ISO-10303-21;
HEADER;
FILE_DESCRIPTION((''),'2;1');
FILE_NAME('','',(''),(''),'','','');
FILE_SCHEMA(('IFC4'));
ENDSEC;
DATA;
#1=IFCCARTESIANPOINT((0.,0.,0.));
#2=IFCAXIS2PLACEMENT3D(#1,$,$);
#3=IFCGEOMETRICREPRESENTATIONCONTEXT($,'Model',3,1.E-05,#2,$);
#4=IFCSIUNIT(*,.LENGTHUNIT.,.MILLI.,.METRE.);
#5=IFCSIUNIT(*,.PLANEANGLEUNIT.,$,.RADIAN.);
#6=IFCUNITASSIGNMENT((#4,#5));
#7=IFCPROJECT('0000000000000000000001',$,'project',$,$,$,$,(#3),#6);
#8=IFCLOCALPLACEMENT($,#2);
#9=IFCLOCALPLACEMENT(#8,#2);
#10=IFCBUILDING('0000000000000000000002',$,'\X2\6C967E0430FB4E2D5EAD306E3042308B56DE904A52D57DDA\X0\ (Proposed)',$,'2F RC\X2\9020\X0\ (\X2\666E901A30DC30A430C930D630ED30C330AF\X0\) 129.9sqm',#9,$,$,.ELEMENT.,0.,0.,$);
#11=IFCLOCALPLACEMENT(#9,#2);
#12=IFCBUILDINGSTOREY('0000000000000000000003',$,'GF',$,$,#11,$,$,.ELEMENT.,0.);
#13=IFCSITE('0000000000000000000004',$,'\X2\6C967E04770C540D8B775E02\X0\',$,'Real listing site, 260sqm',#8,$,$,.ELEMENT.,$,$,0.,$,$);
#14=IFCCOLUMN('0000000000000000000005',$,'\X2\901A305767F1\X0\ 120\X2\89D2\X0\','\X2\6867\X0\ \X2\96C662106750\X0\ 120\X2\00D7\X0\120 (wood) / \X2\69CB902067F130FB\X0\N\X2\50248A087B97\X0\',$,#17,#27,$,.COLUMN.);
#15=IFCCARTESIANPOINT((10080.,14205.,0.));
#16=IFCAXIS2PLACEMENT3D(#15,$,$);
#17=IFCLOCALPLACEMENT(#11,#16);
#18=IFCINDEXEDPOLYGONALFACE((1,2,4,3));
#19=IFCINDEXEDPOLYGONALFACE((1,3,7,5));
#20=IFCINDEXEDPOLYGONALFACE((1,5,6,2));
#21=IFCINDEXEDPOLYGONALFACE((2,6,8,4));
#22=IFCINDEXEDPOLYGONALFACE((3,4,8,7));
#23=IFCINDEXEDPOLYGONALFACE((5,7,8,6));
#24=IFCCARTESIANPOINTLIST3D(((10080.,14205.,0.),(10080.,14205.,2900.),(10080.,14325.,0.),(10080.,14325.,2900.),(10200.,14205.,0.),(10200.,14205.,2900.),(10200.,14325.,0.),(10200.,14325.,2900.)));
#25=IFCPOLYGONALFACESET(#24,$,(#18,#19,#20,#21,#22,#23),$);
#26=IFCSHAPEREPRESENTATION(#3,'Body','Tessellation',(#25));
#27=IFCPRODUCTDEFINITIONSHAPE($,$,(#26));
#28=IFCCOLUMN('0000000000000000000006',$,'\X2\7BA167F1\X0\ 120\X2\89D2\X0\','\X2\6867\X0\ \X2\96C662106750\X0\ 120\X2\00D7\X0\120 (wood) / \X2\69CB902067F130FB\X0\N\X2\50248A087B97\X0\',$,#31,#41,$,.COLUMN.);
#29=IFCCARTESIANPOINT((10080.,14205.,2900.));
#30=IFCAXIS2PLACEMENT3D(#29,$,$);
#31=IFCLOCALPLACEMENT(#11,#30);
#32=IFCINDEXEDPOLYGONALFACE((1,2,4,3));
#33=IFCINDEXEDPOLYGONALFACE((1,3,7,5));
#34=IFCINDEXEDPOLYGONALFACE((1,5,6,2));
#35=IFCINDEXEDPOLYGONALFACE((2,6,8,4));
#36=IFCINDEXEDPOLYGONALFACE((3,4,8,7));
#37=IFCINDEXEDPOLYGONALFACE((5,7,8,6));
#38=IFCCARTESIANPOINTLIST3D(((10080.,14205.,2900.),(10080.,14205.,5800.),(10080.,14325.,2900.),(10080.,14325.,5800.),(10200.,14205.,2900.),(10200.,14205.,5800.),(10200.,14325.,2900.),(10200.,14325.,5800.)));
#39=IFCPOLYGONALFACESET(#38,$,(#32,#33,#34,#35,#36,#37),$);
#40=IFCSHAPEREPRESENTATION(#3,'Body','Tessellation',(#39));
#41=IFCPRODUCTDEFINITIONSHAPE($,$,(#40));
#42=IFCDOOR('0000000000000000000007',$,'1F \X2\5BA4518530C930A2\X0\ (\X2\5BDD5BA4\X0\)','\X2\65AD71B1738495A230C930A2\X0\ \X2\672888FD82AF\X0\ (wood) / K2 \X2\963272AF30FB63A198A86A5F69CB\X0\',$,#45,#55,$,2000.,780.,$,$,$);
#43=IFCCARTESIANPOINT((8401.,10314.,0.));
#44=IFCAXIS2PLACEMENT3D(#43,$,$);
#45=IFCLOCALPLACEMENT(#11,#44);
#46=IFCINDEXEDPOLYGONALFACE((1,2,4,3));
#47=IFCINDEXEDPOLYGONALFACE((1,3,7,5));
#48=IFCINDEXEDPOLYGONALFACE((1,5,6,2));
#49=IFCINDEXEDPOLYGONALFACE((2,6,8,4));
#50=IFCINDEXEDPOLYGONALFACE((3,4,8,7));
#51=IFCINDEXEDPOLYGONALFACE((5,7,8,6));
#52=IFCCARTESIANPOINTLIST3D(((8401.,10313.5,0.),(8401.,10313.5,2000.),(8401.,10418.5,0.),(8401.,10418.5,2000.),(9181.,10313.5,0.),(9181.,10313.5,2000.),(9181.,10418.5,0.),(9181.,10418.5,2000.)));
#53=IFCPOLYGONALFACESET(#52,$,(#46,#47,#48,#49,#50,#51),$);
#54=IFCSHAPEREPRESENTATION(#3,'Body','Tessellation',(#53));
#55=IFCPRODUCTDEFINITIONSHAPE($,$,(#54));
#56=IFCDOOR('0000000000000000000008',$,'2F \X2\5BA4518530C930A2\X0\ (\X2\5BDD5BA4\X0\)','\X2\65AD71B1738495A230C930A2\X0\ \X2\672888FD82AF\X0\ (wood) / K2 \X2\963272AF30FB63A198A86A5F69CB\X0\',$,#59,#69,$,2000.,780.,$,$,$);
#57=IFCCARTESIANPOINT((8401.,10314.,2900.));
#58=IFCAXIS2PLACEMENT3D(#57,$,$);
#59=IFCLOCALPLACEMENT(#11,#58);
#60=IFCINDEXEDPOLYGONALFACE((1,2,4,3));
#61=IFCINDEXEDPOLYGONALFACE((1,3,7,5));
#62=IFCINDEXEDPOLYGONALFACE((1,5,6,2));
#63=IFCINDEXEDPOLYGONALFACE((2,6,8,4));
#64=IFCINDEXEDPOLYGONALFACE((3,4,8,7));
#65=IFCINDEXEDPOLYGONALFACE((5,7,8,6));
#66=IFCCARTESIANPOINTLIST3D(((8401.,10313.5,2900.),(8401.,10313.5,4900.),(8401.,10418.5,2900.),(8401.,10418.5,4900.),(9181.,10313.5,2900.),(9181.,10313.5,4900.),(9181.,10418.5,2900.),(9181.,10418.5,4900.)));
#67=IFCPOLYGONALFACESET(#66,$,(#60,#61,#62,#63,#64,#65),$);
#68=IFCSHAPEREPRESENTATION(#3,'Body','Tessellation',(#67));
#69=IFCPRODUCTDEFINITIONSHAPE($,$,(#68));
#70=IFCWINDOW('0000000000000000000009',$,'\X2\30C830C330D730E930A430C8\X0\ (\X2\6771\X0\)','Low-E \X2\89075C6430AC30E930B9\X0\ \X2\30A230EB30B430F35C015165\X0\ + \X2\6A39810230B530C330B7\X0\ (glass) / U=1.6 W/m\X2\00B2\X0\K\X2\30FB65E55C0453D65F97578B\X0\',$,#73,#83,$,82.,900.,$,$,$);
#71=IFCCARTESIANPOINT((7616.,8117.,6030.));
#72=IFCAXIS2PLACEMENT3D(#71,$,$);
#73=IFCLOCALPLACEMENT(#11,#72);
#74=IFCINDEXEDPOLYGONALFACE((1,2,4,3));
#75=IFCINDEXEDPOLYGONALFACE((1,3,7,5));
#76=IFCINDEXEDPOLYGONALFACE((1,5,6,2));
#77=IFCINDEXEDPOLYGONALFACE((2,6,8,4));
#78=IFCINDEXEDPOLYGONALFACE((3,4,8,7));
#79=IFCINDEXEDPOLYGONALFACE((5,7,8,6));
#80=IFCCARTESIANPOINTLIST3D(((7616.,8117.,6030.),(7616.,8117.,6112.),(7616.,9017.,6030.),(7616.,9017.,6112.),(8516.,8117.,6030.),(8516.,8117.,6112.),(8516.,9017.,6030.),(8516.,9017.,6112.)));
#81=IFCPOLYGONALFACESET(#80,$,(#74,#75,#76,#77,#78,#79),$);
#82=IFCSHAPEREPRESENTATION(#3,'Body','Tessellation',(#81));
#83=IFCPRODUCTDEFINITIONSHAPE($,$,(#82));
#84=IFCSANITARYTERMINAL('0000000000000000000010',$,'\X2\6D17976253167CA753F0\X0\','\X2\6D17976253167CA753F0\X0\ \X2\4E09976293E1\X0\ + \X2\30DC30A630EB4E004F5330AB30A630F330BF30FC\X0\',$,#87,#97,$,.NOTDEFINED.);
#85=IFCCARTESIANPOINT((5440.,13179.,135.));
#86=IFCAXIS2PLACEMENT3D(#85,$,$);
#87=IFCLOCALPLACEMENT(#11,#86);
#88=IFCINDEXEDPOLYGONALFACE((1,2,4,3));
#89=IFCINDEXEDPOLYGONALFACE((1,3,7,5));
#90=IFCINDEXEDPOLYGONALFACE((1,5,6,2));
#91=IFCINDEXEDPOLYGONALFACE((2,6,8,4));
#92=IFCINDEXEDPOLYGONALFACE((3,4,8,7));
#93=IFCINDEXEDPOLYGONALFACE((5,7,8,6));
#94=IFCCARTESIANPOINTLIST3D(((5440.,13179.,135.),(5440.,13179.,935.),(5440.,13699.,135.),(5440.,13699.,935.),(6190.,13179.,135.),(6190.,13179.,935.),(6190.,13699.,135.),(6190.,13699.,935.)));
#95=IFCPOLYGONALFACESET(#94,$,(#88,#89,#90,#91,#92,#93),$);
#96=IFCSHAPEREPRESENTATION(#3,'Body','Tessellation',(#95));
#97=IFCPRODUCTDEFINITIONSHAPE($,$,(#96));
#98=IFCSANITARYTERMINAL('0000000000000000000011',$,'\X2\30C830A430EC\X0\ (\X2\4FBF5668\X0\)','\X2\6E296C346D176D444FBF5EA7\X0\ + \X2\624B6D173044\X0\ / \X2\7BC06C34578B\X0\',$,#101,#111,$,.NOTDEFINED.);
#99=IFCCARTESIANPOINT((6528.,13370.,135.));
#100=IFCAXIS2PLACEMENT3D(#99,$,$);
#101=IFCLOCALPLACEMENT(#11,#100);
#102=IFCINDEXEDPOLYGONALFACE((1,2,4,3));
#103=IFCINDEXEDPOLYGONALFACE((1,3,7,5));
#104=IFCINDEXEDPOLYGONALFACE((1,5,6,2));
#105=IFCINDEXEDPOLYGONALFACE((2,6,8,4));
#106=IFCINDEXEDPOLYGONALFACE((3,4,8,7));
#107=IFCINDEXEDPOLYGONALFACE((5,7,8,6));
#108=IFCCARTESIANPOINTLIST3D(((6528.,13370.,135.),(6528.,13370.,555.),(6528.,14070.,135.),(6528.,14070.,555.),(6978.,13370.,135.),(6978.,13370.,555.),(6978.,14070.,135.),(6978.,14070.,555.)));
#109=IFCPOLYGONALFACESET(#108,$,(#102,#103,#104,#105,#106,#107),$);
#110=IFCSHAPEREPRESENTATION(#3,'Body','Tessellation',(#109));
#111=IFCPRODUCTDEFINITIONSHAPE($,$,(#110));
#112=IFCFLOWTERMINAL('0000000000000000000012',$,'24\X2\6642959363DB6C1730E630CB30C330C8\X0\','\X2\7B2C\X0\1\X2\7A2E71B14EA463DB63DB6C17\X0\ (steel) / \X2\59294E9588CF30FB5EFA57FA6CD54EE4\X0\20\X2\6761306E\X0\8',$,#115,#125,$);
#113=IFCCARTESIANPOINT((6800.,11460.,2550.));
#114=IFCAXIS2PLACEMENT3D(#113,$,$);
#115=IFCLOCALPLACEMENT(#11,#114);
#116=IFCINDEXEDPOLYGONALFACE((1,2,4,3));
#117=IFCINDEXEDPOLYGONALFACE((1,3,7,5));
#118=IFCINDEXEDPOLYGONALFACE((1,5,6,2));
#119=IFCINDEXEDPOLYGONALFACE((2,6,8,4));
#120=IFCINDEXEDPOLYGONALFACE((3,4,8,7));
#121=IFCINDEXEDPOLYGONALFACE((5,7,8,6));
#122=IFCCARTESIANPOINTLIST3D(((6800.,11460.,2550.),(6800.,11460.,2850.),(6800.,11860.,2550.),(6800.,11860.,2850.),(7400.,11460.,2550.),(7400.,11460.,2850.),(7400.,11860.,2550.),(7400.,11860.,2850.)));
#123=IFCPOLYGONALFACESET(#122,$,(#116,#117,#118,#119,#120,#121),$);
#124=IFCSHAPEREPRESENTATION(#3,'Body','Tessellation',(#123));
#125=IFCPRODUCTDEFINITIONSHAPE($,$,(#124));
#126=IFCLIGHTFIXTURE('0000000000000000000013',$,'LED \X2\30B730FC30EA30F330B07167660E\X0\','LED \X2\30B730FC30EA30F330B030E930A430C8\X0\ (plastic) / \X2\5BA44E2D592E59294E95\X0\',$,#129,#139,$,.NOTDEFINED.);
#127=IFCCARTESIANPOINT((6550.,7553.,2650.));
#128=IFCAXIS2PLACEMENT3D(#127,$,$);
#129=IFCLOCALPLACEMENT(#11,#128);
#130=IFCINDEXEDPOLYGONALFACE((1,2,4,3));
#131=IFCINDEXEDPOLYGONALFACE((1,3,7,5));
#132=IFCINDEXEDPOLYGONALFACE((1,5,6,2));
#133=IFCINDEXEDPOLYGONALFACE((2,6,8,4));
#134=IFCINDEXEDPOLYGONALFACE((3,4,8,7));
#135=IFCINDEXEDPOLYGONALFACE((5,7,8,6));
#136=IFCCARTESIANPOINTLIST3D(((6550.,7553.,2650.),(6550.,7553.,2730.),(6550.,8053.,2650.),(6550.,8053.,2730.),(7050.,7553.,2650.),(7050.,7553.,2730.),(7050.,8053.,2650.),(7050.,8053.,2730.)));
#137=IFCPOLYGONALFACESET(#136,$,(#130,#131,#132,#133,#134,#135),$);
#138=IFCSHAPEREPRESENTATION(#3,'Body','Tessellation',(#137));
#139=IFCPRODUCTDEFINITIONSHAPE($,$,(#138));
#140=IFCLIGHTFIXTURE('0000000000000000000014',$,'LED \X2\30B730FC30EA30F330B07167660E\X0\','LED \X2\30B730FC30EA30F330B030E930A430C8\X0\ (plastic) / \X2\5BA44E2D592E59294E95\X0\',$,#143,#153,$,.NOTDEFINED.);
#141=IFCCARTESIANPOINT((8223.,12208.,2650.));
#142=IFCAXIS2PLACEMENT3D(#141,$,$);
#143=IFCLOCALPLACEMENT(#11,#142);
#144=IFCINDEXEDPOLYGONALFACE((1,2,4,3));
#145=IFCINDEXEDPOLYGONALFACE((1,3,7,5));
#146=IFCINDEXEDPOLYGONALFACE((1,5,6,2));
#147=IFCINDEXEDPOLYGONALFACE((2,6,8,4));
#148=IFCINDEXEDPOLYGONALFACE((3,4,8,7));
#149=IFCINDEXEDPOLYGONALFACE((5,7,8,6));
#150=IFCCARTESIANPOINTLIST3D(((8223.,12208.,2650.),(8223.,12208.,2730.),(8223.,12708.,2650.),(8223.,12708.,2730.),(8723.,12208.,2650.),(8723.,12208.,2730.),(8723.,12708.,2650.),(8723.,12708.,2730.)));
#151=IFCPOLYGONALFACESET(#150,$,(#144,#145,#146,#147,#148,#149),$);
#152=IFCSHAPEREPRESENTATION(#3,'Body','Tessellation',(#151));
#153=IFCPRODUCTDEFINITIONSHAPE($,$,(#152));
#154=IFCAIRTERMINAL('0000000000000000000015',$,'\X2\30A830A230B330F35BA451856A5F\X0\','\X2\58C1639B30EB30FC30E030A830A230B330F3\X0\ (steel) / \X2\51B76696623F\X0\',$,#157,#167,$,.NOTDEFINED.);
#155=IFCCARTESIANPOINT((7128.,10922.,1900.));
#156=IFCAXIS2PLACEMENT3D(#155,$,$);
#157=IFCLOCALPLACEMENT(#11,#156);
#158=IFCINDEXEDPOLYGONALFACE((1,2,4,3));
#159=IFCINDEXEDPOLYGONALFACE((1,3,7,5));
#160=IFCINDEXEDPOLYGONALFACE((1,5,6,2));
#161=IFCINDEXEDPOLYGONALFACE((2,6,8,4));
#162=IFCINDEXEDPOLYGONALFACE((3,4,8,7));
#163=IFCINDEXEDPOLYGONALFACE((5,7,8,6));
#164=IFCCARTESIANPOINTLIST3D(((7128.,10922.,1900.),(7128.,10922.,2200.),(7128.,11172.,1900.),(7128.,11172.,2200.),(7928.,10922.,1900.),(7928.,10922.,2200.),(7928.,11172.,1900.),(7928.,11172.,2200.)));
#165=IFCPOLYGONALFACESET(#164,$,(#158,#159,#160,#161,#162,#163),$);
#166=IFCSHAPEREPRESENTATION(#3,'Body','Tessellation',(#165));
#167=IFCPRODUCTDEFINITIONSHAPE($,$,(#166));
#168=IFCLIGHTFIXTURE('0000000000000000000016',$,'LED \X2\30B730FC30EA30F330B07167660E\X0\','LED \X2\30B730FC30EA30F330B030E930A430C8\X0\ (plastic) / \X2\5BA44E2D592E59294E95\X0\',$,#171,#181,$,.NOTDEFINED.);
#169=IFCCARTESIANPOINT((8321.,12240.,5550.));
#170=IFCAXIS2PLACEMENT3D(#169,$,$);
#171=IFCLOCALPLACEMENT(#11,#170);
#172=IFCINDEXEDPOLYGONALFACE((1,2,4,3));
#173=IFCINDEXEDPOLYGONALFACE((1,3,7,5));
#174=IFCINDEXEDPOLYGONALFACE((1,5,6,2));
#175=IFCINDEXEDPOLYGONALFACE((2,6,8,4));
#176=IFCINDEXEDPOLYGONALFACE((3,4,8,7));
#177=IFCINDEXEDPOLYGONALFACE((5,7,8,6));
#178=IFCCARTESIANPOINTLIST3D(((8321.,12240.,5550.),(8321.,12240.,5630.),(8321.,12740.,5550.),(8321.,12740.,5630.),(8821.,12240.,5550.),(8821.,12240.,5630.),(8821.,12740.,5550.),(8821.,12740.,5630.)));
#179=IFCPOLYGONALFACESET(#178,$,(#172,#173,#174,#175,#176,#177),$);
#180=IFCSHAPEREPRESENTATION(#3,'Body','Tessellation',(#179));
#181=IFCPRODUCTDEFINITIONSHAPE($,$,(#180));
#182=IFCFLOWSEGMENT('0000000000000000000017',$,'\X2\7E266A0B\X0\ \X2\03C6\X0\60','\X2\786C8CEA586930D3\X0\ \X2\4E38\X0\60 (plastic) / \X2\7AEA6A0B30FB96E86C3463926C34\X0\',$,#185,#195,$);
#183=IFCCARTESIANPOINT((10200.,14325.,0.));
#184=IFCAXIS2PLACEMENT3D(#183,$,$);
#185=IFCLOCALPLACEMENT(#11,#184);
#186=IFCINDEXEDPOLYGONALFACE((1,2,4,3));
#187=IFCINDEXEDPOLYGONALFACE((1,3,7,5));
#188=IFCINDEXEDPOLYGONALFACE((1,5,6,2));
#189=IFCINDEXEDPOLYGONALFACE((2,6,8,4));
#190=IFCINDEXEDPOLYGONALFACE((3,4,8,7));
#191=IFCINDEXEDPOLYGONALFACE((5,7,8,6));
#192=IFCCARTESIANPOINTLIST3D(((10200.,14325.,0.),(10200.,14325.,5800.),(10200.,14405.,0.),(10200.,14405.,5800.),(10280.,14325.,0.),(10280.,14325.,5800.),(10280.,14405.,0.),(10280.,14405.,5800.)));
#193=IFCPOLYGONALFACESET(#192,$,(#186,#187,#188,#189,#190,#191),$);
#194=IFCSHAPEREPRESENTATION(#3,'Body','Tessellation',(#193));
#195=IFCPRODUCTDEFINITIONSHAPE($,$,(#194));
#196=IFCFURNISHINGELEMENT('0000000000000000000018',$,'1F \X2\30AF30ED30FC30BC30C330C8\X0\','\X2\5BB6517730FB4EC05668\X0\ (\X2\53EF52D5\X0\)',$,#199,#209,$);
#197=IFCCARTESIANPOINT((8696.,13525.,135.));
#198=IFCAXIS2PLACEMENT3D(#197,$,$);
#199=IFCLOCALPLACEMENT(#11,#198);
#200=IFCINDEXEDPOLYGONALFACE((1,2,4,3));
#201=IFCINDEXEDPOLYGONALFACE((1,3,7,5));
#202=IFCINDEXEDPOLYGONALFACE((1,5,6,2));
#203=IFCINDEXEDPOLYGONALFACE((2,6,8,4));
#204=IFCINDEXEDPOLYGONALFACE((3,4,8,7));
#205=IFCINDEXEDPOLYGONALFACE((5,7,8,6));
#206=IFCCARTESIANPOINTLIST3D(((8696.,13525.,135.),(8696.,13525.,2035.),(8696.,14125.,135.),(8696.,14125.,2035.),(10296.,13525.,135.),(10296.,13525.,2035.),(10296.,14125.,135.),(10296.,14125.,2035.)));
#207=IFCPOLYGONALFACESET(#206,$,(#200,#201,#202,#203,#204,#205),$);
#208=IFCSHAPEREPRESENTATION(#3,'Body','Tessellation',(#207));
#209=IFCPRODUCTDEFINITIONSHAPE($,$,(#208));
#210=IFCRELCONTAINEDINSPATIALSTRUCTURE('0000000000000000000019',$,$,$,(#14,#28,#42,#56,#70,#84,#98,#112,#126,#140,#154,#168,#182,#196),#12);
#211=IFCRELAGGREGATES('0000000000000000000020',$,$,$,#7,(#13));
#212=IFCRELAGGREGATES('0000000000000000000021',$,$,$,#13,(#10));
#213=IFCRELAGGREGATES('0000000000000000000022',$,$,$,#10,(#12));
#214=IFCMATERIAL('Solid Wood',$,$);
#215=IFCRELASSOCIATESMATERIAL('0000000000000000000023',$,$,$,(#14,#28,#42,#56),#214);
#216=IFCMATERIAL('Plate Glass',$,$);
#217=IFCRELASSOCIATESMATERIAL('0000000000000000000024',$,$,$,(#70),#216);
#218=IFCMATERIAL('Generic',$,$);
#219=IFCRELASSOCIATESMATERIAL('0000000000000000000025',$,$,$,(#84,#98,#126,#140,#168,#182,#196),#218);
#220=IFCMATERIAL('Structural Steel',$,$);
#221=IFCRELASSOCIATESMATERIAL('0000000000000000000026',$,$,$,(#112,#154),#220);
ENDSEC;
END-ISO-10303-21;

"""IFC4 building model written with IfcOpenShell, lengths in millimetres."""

from ifc_helpers import new_model, si_unit, frame, frame_2d, origin, place, context, project, spatial, rectangle, extrude, material, element, save


model = new_model("IFC4")

# Units and contexts
model_context = context("Model", 3, precision=1e-05, world=origin())
ifc_project = project(units=[si_unit("LENGTHUNIT", "METRE", prefix="MILLI"), si_unit("PLANEANGLEUNIT", "RADIAN")], contexts=[model_context])

# Site, building, storey
site_placement = place(None, origin())
site = spatial("IfcSite", under=ifc_project, at=site_placement, Name="沖縄県名護市", ObjectType="Real listing site, 260sqm", CompositionType="ELEMENT", RefElevation=0.0)
building_placement = place(site_placement, origin())
building = spatial("IfcBuilding", under=site, at=building_placement, Name="沖縄・中庭のある回遊動線 (Proposed)", ObjectType="2F RC造 (普通ボイドブロック) 129.9sqm", CompositionType="ELEMENT", ElevationOfRefHeight=0.0, ElevationOfTerrain=0.0)
storey_placement = place(building_placement, origin())
storey = spatial("IfcBuildingStorey", under=building, at=storey_placement, Name="GF", CompositionType="ELEMENT", Elevation=0.0)

# Columns
ifc_material_1 = material(Name="Solid Wood")
column_1_placement = place(storey_placement, frame((10080.0, 14205.0, 0.0)))
element("IfcColumn", 1, at=column_1_placement, inside=storey, material=ifc_material_1, Name="通し柱 120角", Description="桧 集成材 120×120 (wood) / 構造柱・N値計算", PredefinedType="COLUMN", context=model_context, shape_type="SweptSolid", body=[
    extrude(rectangle(XDim=120.0, YDim=120.0, at=frame_2d((60.0, 60.0))), frame((10080.0, 14205.0, 0.0)), (0.0, 0.0, 1.0), 2900.0),
])
column_2_placement = place(storey_placement, frame((10080.0, 14205.0, 2900.0)))
element("IfcColumn", 2, at=column_2_placement, inside=storey, material=ifc_material_1, Name="管柱 120角", Description="桧 集成材 120×120 (wood) / 構造柱・N値計算", PredefinedType="COLUMN", context=model_context, shape_type="SweptSolid", body=[
    extrude(rectangle(XDim=120.0, YDim=120.0, at=frame_2d((60.0, 60.0))), frame((10080.0, 14205.0, 2900.0)), (0.0, 0.0, 1.0), 2900.0),
])

# Door
door_1_placement = place(storey_placement, frame((8401.0, 10314.0, 0.0)))
element("IfcDoor", 3, at=door_1_placement, inside=storey, material=ifc_material_1, Name="1F 室内ドア (寝室)", Description="断熱玄関ドア 木製芯 (wood) / K2 防犯・採風機構", OverallHeight=2000.0, OverallWidth=780.0, context=model_context, shape_type="SweptSolid", body=[
    extrude(rectangle(XDim=780.0, YDim=105.0, at=frame_2d((390.0, 52.0))), frame((8401.0, 10314.0, 0.0)), (0.0, 0.0, 1.0), 2000.0),
])

# Door
door_2_placement = place(storey_placement, frame((8401.0, 10314.0, 2900.0)))
element("IfcDoor", 4, at=door_2_placement, inside=storey, material=ifc_material_1, Name="2F 室内ドア (寝室)", Description="断熱玄関ドア 木製芯 (wood) / K2 防犯・採風機構", OverallHeight=2000.0, OverallWidth=780.0, context=model_context, shape_type="SweptSolid", body=[
    extrude(rectangle(XDim=780.0, YDim=105.0, at=frame_2d((390.0, 52.0))), frame((8401.0, 10314.0, 2900.0)), (0.0, 0.0, 1.0), 2000.0),
])

# Window
ifc_material_2 = material(Name="Plate Glass")
window_placement = place(storey_placement, frame((7616.0, 8117.0, 6030.0)))
element("IfcWindow", 5, at=window_placement, inside=storey, material=ifc_material_2, Name="トップライト (東)", Description="Low-E 複層ガラス アルゴン封入 + 樹脂サッシ (glass) / U=1.6 W/m²K・日射取得型", OverallHeight=82.0, OverallWidth=900.0, context=model_context, shape_type="SweptSolid", body=[
    extrude(rectangle(XDim=900.0, YDim=900.0, at=frame_2d((450.0, 450.0))), frame((7616.0, 8117.0, 6030.0)), (0.0, 0.0, 1.0), 82.0),
])

# Sanitary terminals
ifc_material_3 = material(Name="Generic")
sanitary_terminal_1_placement = place(storey_placement, frame((5440.0, 13179.0, 135.0)))
element("IfcSanitaryTerminal", 6, at=sanitary_terminal_1_placement, inside=storey, material=ifc_material_3, Name="洗面化粧台", Description="洗面化粧台 三面鏡 + ボウル一体カウンター", PredefinedType="NOTDEFINED", context=model_context, shape_type="SweptSolid", body=[
    extrude(rectangle(XDim=750.0, YDim=520.0, at=frame_2d((375.0, 260.0))), frame((5440.0, 13179.0, 135.0)), (0.0, 0.0, 1.0), 800.0),
])
sanitary_terminal_2_placement = place(storey_placement, frame((6528.0, 13370.0, 135.0)))
element("IfcSanitaryTerminal", 7, at=sanitary_terminal_2_placement, inside=storey, material=ifc_material_3, Name="トイレ (便器)", Description="温水洗浄便座 + 手洗い / 節水型", PredefinedType="NOTDEFINED", context=model_context, shape_type="SweptSolid", body=[
    extrude(rectangle(XDim=450.0, YDim=700.0, at=frame_2d((225.0, 350.0))), frame((6528.0, 13370.0, 135.0)), (0.0, 0.0, 1.0), 420.0),
])

# Flow terminal
ifc_material_4 = material(Name="Structural Steel")
flow_terminal_placement = place(storey_placement, frame((6800.0, 11460.0, 2550.0)))
element("IfcFlowTerminal", 8, at=flow_terminal_placement, inside=storey, material=ifc_material_4, Name="24時間換気ユニット", Description="第1種熱交換換気 (steel) / 天井裏・建基法令20条の8", context=model_context, shape_type="SweptSolid", body=[
    extrude(rectangle(XDim=600.0, YDim=400.0, at=frame_2d((300.0, 200.0))), frame((6800.0, 11460.0, 2550.0)), (0.0, 0.0, 1.0), 300.0),
])

# Light fixtures
light_fixture_1_placement = place(storey_placement, frame((6550.0, 7553.0, 2650.0)))
element("IfcLightFixture", 9, at=light_fixture_1_placement, inside=storey, material=ifc_material_3, Name="LED シーリング照明", Description="LED シーリングライト (plastic) / 室中央天井", PredefinedType="NOTDEFINED", context=model_context, shape_type="SweptSolid", body=[
    extrude(rectangle(XDim=500.0, YDim=500.0, at=frame_2d((250.0, 250.0))), frame((6550.0, 7553.0, 2650.0)), (0.0, 0.0, 1.0), 80.0),
])
light_fixture_2_placement = place(storey_placement, frame((8223.0, 12208.0, 2650.0)))
element("IfcLightFixture", 10, at=light_fixture_2_placement, inside=storey, material=ifc_material_3, Name="LED シーリング照明", Description="LED シーリングライト (plastic) / 室中央天井", PredefinedType="NOTDEFINED", context=model_context, shape_type="SweptSolid", body=[
    extrude(rectangle(XDim=500.0, YDim=500.0, at=frame_2d((250.0, 250.0))), frame((8223.0, 12208.0, 2650.0)), (0.0, 0.0, 1.0), 80.0),
])

# Air terminal
air_terminal_placement = place(storey_placement, frame((7128.0, 10922.0, 1900.0)))
element("IfcAirTerminal", 11, at=air_terminal_placement, inside=storey, material=ifc_material_4, Name="エアコン室内機", Description="壁掛ルームエアコン (steel) / 冷暖房", PredefinedType="NOTDEFINED", context=model_context, shape_type="SweptSolid", body=[
    extrude(rectangle(XDim=800.0, YDim=250.0, at=frame_2d((400.0, 125.0))), frame((7128.0, 10922.0, 1900.0)), (0.0, 0.0, 1.0), 300.0),
])

# Light fixture
light_fixture_3_placement = place(storey_placement, frame((8321.0, 12240.0, 5550.0)))
element("IfcLightFixture", 12, at=light_fixture_3_placement, inside=storey, material=ifc_material_3, Name="LED シーリング照明", Description="LED シーリングライト (plastic) / 室中央天井", PredefinedType="NOTDEFINED", context=model_context, shape_type="SweptSolid", body=[
    extrude(rectangle(XDim=500.0, YDim=500.0, at=frame_2d((250.0, 250.0))), frame((8321.0, 12240.0, 5550.0)), (0.0, 0.0, 1.0), 80.0),
])

# Flow segment
flow_segment_placement = place(storey_placement, frame((10200.0, 14325.0, 0.0)))
element("IfcFlowSegment", 13, at=flow_segment_placement, inside=storey, material=ifc_material_3, Name="縦樋 φ60", Description="硬質塩ビ 丸60 (plastic) / 竪樋・雨水排水", context=model_context, shape_type="SweptSolid", body=[
    extrude(rectangle(XDim=80.0, YDim=80.0, at=frame_2d((40.0, 40.0))), frame((10200.0, 14325.0, 0.0)), (0.0, 0.0, 1.0), 5800.0),
])

# Furnishing element
furnishing_1_placement = place(storey_placement, frame((8696.0, 13525.0, 135.0)))
element("IfcFurnishingElement", 14, at=furnishing_1_placement, inside=storey, material=ifc_material_3, Name="1F クローゼット", Description="家具・什器 (可動)", context=model_context, shape_type="SweptSolid", body=[
    extrude(rectangle(XDim=1600.0, YDim=600.0, at=frame_2d((800.0, 300.0))), frame((8696.0, 13525.0, 135.0)), (0.0, 0.0, 1.0), 1900.0),
])

save(model, "model.ifc")
